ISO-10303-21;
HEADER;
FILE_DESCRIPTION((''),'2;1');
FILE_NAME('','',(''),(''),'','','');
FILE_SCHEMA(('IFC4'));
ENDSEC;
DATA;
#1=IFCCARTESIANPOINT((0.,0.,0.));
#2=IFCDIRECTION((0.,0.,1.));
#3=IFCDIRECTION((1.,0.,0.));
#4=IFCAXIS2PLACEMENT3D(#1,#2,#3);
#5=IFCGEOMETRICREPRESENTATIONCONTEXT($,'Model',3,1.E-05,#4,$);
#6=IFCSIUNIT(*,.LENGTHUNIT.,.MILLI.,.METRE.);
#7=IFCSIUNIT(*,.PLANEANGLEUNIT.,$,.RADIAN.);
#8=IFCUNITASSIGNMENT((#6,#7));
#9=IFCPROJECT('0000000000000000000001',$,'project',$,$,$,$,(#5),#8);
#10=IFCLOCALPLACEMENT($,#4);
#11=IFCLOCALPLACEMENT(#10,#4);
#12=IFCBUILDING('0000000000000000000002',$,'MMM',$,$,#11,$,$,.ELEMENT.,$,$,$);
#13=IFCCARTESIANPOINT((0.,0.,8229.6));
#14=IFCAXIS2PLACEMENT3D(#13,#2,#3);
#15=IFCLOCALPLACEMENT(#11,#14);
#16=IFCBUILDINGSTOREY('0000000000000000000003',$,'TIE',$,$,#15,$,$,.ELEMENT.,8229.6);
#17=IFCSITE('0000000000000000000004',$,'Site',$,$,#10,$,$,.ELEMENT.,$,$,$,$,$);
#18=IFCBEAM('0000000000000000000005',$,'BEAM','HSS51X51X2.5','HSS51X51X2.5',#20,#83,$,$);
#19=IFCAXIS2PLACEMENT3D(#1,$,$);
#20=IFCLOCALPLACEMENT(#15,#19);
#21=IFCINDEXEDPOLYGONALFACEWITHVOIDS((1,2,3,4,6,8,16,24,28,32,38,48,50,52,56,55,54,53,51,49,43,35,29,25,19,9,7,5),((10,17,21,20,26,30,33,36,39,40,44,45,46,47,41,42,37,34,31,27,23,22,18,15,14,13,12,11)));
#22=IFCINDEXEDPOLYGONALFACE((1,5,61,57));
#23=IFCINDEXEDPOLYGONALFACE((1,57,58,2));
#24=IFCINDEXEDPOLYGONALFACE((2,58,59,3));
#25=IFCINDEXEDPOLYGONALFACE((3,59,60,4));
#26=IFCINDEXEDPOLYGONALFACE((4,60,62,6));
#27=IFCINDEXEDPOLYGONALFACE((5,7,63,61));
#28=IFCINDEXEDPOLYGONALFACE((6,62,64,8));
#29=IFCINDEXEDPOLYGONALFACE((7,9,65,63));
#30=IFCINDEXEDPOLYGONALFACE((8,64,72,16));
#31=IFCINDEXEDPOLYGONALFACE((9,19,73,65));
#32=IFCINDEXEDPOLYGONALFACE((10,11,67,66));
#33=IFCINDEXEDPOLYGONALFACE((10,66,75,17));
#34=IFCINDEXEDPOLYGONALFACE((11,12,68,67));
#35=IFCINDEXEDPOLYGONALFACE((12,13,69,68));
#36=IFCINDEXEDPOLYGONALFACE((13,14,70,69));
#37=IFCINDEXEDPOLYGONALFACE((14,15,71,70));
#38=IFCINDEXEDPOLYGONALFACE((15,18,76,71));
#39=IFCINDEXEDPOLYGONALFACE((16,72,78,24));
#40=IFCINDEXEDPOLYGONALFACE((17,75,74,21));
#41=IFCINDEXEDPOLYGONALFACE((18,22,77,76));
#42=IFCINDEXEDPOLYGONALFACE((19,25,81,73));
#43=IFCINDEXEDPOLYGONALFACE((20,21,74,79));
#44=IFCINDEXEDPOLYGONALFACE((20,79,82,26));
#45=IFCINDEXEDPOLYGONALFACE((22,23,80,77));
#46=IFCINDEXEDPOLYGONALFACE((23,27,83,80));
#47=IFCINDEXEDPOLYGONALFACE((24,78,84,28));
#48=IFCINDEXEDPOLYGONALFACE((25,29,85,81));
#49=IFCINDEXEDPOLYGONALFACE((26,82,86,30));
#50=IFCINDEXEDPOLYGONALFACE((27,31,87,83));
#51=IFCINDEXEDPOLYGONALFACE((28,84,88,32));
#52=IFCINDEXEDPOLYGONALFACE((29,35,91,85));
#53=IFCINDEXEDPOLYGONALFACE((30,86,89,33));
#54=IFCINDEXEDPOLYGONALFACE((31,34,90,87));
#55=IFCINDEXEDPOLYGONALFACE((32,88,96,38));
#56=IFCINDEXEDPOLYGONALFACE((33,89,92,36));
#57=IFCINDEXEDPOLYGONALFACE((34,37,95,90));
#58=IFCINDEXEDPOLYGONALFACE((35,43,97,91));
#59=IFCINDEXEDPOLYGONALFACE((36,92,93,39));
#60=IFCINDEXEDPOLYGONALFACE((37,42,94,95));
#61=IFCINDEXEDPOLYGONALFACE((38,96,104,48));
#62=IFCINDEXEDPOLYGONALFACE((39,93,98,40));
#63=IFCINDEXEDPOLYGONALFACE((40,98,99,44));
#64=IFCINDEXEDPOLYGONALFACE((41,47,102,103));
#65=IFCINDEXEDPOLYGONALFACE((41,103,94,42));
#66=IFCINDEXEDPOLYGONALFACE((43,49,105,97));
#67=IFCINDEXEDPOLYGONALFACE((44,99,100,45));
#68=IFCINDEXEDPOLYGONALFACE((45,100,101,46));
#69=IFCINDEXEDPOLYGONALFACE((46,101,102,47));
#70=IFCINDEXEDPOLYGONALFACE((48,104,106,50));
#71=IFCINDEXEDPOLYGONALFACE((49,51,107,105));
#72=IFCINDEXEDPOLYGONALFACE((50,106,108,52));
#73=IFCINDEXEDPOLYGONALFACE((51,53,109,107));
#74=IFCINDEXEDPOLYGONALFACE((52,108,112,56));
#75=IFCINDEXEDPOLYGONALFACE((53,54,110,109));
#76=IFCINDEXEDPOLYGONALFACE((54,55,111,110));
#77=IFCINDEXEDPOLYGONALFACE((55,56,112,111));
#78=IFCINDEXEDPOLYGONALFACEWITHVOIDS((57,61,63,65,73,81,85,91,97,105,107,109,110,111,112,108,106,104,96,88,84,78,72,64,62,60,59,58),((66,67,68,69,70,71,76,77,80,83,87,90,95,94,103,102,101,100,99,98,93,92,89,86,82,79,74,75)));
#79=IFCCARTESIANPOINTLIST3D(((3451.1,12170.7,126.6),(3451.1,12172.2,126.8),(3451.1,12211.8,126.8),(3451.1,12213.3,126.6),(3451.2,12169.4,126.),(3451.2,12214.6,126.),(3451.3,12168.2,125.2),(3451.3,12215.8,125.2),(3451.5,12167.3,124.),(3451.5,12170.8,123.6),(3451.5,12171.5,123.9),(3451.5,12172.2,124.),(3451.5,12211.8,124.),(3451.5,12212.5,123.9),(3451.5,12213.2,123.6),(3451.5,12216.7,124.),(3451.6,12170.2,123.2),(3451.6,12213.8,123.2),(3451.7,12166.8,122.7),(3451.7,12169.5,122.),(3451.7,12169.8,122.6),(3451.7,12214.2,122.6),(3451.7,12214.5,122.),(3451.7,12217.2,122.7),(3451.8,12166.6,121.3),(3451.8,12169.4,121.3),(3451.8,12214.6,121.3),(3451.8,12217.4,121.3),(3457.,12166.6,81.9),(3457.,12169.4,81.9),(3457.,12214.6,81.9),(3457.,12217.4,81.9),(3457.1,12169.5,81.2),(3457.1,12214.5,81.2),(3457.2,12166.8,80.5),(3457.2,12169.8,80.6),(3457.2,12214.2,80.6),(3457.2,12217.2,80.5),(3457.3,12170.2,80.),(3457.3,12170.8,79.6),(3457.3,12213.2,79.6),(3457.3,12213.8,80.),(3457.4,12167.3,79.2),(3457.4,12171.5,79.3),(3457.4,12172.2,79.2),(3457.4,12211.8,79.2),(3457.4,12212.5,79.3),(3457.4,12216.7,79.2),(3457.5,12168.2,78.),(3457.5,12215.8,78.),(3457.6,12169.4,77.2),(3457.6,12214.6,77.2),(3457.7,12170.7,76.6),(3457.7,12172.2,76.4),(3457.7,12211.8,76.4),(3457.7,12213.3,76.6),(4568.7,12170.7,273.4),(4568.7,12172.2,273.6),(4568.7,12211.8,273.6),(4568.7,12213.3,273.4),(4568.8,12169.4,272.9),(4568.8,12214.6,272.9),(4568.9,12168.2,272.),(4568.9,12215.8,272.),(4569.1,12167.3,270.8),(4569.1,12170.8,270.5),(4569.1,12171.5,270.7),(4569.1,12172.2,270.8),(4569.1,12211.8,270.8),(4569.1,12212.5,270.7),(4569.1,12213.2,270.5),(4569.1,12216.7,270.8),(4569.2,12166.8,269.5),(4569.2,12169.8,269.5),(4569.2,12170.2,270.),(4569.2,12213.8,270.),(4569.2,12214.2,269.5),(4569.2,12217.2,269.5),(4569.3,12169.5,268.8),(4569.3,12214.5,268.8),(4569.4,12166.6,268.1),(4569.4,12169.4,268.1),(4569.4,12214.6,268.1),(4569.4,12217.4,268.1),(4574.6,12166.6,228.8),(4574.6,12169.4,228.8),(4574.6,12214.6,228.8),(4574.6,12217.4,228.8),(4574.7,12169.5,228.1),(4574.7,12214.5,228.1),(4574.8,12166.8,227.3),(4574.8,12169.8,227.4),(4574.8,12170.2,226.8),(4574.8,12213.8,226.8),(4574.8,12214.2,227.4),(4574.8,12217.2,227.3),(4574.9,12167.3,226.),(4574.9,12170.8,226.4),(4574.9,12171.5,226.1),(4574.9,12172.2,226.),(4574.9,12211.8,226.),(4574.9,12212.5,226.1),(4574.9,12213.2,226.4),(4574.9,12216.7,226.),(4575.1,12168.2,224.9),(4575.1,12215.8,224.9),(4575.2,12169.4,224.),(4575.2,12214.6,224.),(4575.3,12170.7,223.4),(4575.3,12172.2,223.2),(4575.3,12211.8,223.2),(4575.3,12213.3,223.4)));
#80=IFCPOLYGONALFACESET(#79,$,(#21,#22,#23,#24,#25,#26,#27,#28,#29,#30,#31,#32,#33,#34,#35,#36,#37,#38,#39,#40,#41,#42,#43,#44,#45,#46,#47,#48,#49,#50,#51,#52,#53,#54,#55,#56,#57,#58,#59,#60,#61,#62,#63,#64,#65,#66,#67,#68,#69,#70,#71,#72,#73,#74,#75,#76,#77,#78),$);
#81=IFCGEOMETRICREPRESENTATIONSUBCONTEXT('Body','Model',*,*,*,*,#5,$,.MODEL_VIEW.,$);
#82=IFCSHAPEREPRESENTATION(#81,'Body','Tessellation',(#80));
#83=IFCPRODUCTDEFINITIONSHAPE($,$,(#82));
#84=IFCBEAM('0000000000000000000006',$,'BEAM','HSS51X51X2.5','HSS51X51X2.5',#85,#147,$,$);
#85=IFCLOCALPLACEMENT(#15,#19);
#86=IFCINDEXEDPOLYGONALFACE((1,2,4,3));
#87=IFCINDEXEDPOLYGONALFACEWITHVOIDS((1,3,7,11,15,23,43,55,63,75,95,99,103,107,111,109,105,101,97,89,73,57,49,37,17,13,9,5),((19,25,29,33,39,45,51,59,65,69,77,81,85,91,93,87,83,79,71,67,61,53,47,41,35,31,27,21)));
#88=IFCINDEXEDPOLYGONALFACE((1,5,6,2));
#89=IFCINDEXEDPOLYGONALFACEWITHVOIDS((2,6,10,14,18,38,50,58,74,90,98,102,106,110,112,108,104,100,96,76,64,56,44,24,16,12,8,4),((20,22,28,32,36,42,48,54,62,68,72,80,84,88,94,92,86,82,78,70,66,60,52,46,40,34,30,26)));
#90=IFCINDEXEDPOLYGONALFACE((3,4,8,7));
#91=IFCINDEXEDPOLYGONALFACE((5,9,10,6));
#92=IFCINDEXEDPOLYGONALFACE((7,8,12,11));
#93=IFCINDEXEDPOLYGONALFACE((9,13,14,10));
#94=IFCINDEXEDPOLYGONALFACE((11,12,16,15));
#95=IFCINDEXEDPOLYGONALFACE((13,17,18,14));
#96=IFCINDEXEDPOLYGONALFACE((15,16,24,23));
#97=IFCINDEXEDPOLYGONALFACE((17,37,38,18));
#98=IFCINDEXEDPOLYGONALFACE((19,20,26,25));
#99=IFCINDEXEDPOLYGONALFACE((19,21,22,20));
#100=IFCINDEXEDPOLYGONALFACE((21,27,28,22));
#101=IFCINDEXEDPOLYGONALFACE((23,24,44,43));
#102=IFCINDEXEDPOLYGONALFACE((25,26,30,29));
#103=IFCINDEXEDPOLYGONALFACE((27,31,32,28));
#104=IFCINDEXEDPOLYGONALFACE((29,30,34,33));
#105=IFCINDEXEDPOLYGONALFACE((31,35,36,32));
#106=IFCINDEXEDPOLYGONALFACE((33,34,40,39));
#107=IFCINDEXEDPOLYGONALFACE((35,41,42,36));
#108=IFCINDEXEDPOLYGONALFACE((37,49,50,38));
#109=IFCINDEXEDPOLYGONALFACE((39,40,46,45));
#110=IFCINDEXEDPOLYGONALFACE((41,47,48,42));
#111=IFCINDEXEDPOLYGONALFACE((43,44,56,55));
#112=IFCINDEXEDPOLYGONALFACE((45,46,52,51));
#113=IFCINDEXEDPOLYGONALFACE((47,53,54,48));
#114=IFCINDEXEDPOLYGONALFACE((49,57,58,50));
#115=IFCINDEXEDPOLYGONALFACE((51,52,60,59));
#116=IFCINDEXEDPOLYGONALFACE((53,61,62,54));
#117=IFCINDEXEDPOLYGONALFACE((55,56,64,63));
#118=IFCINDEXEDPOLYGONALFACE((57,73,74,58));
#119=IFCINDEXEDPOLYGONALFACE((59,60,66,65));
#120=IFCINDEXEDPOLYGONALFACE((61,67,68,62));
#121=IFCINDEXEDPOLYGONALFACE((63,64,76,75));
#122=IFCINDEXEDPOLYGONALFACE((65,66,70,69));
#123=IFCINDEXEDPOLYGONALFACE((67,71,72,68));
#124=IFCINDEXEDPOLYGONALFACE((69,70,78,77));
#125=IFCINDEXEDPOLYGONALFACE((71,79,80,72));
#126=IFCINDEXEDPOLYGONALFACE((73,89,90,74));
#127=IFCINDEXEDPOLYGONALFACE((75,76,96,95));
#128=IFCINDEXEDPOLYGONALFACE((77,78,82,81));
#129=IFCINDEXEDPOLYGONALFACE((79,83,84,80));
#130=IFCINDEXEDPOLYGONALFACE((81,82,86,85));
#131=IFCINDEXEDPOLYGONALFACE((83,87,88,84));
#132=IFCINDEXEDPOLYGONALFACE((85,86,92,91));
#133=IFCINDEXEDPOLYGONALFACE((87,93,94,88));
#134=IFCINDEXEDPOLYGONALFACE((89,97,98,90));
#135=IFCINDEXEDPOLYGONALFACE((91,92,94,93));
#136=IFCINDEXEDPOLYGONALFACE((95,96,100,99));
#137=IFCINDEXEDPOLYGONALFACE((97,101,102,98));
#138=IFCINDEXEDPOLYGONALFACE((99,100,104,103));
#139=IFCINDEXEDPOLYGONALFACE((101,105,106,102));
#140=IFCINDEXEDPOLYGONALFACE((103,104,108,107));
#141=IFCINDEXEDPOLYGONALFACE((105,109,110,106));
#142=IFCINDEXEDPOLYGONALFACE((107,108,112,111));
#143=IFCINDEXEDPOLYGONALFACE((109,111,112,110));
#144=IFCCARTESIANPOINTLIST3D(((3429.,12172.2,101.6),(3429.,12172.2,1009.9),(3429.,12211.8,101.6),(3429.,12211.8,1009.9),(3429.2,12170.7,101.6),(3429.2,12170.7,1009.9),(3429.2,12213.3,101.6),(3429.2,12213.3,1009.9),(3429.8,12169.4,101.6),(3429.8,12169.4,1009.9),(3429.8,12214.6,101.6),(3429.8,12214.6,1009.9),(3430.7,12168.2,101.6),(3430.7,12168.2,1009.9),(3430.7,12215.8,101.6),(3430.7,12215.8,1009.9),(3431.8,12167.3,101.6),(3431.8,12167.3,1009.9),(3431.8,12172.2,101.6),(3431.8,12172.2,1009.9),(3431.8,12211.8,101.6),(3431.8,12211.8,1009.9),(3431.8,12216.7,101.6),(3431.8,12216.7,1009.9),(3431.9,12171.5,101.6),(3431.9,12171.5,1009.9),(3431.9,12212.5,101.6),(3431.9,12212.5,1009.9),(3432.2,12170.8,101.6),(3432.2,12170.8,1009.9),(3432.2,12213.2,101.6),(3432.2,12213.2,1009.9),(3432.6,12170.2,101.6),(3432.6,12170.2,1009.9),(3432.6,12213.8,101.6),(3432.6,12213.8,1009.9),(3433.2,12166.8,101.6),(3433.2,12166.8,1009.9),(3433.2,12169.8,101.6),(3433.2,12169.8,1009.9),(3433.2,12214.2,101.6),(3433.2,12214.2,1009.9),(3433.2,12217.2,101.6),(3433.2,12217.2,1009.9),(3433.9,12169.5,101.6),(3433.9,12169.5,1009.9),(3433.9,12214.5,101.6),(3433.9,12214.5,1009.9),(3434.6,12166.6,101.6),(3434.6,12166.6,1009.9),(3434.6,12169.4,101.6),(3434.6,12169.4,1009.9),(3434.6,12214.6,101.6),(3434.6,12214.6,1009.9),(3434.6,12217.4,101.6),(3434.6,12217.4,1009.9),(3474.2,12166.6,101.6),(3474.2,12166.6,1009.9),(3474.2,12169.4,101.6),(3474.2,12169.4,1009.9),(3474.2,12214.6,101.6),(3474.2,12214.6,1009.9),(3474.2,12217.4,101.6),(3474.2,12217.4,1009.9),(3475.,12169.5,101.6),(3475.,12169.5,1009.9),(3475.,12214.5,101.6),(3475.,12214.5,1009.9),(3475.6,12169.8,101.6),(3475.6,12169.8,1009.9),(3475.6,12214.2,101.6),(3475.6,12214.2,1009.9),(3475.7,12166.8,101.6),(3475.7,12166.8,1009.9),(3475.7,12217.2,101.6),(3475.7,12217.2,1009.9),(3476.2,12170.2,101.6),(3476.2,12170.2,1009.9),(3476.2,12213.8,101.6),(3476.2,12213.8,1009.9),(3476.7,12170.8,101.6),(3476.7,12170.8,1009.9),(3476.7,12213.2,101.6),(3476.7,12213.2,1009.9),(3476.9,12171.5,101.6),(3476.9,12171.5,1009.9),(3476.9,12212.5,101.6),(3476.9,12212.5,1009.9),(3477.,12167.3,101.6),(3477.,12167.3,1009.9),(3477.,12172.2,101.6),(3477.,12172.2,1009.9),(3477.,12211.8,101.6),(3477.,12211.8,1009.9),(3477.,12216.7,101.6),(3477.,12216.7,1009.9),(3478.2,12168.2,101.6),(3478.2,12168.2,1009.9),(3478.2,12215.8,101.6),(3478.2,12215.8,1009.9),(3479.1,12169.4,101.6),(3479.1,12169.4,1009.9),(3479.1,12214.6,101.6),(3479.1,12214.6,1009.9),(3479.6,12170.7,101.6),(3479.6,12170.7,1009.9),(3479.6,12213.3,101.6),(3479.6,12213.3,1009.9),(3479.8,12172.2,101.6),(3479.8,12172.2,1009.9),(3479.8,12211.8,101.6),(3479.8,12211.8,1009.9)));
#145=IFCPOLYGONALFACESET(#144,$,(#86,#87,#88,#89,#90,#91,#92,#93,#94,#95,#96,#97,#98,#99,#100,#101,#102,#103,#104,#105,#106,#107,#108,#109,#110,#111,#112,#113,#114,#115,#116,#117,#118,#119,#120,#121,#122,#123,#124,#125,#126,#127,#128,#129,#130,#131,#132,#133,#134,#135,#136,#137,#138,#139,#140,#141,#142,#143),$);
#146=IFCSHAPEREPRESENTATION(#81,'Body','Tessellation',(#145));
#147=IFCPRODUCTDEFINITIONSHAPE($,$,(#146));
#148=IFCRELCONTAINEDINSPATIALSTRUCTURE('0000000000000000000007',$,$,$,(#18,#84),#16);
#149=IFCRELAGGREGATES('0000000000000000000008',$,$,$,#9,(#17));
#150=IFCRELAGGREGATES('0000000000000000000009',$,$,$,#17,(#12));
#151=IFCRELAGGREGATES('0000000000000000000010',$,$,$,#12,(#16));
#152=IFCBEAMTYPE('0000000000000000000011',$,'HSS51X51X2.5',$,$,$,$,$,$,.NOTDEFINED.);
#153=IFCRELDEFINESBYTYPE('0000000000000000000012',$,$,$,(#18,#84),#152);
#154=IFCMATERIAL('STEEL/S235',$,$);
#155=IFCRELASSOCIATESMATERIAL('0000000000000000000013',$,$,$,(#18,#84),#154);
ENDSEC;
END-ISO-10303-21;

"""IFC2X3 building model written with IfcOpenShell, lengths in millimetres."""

from ifc_helpers import new_model, si_unit, frame, origin_with_axes, origin_2d_with_axis, place, context, subcontext, project, spatial, hollow_rectangle, extrude, material, type_object, element, save


model = new_model("IFC2X3")

# Units and contexts
model_context = context("Model", 3, precision=1e-05, world=origin_with_axes())
body_context = subcontext(model_context, "Body", "Model", "MODEL_VIEW")
ifc_project = project(units=[si_unit("LENGTHUNIT", "METRE", prefix="MILLI"), si_unit("PLANEANGLEUNIT", "RADIAN")], contexts=[model_context])

# Site, building, storey
site_placement = place(None, origin_with_axes())
site = spatial("IfcSite", under=ifc_project, at=site_placement, Name="Site", CompositionType="ELEMENT")
building_placement = place(site_placement, origin_with_axes())
building = spatial("IfcBuilding", under=site, at=building_placement, Name="MMM", CompositionType="ELEMENT")
storey_placement = place(building_placement, frame((0.0, 0.0, 8229.6), z_axis=(0.0, 0.0, 1.0), x_axis=(1.0, 0.0, 0.0)))
storey = spatial("IfcBuildingStorey", under=building, at=storey_placement, Name="TIE", CompositionType="ELEMENT", Elevation=8229.6)

# Beams
ifc_material = material(Name="STEEL/S235")
beam_type_1 = type_object("IfcBeamType", Name="HSS51X51X2.5", PredefinedType="NOTDEFINED")
beam_1_placement = place(storey_placement, frame((3454.4, 12192.0, 101.6), z_axis=(-0.130258, 0.0, 0.99148), x_axis=(0.99148, 0.0, 0.130258)))
element("IfcBeam", 1, at=beam_1_placement, inside=storey, type_object=beam_type_1, material=ifc_material, Name="BEAM", Description="HSS51X51X2.5", ObjectType="HSS51X51X2.5", context=body_context, shape_type="SweptSolid", body=[
    extrude(hollow_rectangle(XDim=50.8, YDim=50.8, WallThickness=2.8, InnerFilletRadius=2.8, OuterFilletRadius=5.6, at=origin_2d_with_axis()), frame((1127.2, 0.0, 0.0), z_axis=(-1.0, 0.0, 0.0), x_axis=(0.0, -1.0, 0.0)), (0.0, 0.0, 1.0), 1127.2),
])
beam_2_placement = place(storey_placement, frame((3454.4, 12192.0, 1009.9), z_axis=(-1.0, 0.0, 0.0), x_axis=(0.0, 0.0, -1.0)))
element("IfcBeam", 2, at=beam_2_placement, inside=storey, type_object=beam_type_1, material=ifc_material, Name="BEAM", Description="HSS51X51X2.5", ObjectType="HSS51X51X2.5", context=body_context, shape_type="SweptSolid", body=[
    extrude(hollow_rectangle(XDim=50.8, YDim=50.8, WallThickness=2.8, InnerFilletRadius=2.8, OuterFilletRadius=5.6, at=origin_2d_with_axis()), frame((908.3, 0.0, 0.0), z_axis=(-1.0, 0.0, 0.0), x_axis=(0.0, -1.0, 0.0)), (0.0, 0.0, 1.0), 908.3),
])

save(model, "model.ifc")
